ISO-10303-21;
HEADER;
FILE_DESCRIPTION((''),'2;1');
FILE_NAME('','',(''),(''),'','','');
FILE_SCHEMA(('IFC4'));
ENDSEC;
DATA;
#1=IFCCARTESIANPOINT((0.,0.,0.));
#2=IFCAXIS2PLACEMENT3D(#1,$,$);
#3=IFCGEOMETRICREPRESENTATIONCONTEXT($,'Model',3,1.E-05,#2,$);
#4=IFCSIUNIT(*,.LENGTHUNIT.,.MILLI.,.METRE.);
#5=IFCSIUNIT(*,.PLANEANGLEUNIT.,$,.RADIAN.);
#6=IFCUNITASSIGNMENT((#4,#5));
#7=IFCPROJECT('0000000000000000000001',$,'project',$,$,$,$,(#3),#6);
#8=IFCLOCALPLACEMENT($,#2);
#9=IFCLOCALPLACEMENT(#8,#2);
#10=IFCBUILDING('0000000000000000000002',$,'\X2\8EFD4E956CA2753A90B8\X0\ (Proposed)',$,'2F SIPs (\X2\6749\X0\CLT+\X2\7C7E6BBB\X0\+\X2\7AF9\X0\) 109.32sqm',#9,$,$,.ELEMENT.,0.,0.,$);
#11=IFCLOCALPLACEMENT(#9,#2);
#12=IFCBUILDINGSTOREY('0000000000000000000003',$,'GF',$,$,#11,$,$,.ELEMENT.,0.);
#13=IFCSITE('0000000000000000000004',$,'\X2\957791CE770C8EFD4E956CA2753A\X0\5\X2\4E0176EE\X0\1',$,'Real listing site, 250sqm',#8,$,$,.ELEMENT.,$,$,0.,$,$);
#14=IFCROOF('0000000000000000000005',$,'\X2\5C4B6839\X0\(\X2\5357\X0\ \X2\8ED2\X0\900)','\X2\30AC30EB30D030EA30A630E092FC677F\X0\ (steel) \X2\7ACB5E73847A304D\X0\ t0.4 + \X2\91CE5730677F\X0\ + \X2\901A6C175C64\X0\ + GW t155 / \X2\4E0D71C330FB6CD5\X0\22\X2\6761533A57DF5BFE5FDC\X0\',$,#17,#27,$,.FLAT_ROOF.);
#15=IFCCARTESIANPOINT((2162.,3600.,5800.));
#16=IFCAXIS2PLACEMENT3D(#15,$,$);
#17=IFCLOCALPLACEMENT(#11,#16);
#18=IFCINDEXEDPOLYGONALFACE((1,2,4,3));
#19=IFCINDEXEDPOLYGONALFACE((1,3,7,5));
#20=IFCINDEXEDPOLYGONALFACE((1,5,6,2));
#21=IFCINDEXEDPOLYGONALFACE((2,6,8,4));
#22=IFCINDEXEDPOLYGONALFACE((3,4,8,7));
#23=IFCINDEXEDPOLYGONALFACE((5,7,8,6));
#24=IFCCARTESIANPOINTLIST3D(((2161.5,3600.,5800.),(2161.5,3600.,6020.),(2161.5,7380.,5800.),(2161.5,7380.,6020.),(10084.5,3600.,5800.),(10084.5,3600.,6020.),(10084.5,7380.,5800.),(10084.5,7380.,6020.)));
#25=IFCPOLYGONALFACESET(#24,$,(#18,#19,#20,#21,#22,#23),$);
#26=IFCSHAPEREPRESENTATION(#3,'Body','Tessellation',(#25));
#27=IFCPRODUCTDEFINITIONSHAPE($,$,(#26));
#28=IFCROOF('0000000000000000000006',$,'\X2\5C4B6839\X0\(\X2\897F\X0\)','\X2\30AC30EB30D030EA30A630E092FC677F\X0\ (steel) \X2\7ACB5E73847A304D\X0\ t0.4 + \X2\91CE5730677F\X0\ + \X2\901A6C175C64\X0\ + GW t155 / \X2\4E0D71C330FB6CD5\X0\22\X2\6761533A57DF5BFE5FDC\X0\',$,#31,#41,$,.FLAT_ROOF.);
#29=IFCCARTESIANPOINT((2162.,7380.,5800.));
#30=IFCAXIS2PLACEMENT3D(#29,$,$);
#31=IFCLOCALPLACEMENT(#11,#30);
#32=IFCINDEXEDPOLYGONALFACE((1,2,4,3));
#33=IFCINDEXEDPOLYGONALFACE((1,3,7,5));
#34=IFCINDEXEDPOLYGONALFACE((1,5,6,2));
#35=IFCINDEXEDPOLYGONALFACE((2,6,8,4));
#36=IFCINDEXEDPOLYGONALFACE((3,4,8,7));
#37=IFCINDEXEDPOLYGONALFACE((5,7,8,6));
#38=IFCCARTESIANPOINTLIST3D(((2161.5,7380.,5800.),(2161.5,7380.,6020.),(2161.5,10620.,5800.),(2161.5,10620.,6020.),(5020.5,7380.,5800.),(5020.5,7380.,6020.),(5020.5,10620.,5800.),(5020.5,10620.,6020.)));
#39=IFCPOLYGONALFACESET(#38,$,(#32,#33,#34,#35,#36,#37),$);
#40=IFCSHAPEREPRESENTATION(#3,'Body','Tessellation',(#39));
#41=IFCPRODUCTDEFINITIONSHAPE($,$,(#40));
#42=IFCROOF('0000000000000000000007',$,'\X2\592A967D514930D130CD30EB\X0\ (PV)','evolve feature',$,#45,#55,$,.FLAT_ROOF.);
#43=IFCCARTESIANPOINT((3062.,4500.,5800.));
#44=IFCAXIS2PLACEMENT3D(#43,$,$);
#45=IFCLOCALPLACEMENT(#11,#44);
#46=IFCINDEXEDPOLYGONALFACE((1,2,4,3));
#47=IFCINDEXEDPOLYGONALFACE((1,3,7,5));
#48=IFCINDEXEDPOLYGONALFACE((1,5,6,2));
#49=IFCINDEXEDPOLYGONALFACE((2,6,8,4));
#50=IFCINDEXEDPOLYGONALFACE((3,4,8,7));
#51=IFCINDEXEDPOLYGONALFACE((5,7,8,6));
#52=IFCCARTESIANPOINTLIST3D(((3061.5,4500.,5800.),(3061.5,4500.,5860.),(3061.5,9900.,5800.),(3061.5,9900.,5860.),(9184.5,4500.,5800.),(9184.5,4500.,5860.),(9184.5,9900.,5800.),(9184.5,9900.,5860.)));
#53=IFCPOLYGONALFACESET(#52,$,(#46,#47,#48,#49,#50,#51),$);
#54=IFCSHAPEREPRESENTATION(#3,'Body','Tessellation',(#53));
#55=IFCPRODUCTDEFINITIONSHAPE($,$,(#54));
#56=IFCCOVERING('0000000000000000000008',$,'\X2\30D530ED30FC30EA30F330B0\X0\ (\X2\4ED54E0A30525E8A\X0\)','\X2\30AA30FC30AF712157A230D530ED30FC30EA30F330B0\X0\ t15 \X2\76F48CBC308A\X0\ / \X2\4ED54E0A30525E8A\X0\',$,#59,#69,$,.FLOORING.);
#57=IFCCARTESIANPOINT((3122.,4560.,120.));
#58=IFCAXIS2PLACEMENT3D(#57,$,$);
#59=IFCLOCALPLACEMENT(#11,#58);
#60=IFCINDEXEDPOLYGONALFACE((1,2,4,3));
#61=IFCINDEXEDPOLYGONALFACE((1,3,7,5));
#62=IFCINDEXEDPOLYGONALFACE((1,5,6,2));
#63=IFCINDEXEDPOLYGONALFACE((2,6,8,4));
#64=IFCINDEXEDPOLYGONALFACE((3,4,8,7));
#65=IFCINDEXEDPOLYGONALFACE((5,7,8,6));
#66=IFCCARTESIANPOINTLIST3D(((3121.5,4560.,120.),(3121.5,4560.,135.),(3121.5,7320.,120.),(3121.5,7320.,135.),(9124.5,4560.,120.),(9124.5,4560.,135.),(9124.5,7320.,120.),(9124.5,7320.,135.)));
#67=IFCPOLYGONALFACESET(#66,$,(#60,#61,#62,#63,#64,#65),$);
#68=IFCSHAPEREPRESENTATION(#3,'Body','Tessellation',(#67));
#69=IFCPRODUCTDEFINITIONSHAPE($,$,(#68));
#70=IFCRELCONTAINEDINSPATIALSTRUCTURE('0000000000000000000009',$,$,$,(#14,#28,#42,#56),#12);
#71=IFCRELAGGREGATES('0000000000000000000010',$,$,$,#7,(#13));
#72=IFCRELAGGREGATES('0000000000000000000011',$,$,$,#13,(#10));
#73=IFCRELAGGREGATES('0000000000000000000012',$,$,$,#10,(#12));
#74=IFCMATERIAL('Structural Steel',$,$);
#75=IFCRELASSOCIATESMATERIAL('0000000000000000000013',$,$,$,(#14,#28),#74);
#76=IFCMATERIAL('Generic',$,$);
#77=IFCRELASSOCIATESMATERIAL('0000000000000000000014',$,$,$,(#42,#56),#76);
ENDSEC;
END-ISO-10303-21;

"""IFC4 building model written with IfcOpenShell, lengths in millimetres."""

from ifc_helpers import new_model, si_unit, frame, frame_2d, origin, place, context, project, spatial, rectangle, extrude, material, element, save


model = new_model("IFC4")

# Units and contexts
model_context = context("Model", 3, precision=1e-05, world=origin())
ifc_project = project(units=[si_unit("LENGTHUNIT", "METRE", prefix="MILLI"), si_unit("PLANEANGLEUNIT", "RADIAN")], contexts=[model_context])

# Site, building, storey
site_placement = place(None, origin())
site = spatial("IfcSite", under=ifc_project, at=site_placement, Name="長野県軽井沢町5丁目1", ObjectType="Real listing site, 250sqm", CompositionType="ELEMENT", RefElevation=0.0)
building_placement = place(site_placement, origin())
building = spatial("IfcBuilding", under=site, at=building_placement, Name="軽井沢町邸 (Proposed)", ObjectType="2F SIPs (杉CLT+籾殻+竹) 109.32sqm", CompositionType="ELEMENT", ElevationOfRefHeight=0.0, ElevationOfTerrain=0.0)
storey_placement = place(building_placement, origin())
storey = spatial("IfcBuildingStorey", under=building, at=storey_placement, Name="GF", CompositionType="ELEMENT", Elevation=0.0)

# Shared definitions
ifc_material_1 = material(Name="Generic")

# Roofs
ifc_material_2 = material(Name="Structural Steel")
roof_1_placement = place(storey_placement, frame((2162.0, 3600.0, 5800.0)))
element("IfcRoof", 1, at=roof_1_placement, inside=storey, material=ifc_material_2, Name="屋根(南 軒900)", Description="ガルバリウム鋼板 (steel) 立平葺き t0.4 + 野地板 + 通気層 + GW t155 / 不燃・法22条区域対応", PredefinedType="FLAT_ROOF", context=model_context, shape_type="SweptSolid", body=[
    extrude(rectangle(XDim=7923.0, YDim=3780.0, at=frame_2d((3961.0, 1890.0))), frame((2162.0, 3600.0, 5800.0)), (0.0, 0.0, 1.0), 220.0),
])
roof_2_placement = place(storey_placement, frame((2162.0, 7380.0, 5800.0)))
element("IfcRoof", 2, at=roof_2_placement, inside=storey, material=ifc_material_2, Name="屋根(西)", Description="ガルバリウム鋼板 (steel) 立平葺き t0.4 + 野地板 + 通気層 + GW t155 / 不燃・法22条区域対応", PredefinedType="FLAT_ROOF", context=model_context, shape_type="SweptSolid", body=[
    extrude(rectangle(XDim=2859.0, YDim=3240.0, at=frame_2d((1429.0, 1620.0))), frame((2162.0, 7380.0, 5800.0)), (0.0, 0.0, 1.0), 220.0),
])
roof_3_placement = place(storey_placement, frame((3062.0, 4500.0, 5800.0)))
element("IfcRoof", 3, at=roof_3_placement, inside=storey, material=ifc_material_1, Name="太陽光パネル (PV)", Description="evolve feature", PredefinedType="FLAT_ROOF", context=model_context, shape_type="SweptSolid", body=[
    extrude(rectangle(XDim=6123.0, YDim=5400.0, at=frame_2d((3061.0, 2700.0))), frame((3062.0, 4500.0, 5800.0)), (0.0, 0.0, 1.0), 60.0),
])

# Covering
covering_placement = place(storey_placement, frame((3122.0, 4560.0, 120.0)))
element("IfcCovering", 4, at=covering_placement, inside=storey, material=ifc_material_1, Name="フローリング (仕上げ床)", Description="オーク無垢フローリング t15 直貼り / 仕上げ床", PredefinedType="FLOORING", context=model_context, shape_type="SweptSolid", body=[
    extrude(rectangle(XDim=6003.0, YDim=2760.0, at=frame_2d((3001.0, 1380.0))), frame((3122.0, 4560.0, 120.0)), (0.0, 0.0, 1.0), 15.0),
])

save(model, "model.ifc")
